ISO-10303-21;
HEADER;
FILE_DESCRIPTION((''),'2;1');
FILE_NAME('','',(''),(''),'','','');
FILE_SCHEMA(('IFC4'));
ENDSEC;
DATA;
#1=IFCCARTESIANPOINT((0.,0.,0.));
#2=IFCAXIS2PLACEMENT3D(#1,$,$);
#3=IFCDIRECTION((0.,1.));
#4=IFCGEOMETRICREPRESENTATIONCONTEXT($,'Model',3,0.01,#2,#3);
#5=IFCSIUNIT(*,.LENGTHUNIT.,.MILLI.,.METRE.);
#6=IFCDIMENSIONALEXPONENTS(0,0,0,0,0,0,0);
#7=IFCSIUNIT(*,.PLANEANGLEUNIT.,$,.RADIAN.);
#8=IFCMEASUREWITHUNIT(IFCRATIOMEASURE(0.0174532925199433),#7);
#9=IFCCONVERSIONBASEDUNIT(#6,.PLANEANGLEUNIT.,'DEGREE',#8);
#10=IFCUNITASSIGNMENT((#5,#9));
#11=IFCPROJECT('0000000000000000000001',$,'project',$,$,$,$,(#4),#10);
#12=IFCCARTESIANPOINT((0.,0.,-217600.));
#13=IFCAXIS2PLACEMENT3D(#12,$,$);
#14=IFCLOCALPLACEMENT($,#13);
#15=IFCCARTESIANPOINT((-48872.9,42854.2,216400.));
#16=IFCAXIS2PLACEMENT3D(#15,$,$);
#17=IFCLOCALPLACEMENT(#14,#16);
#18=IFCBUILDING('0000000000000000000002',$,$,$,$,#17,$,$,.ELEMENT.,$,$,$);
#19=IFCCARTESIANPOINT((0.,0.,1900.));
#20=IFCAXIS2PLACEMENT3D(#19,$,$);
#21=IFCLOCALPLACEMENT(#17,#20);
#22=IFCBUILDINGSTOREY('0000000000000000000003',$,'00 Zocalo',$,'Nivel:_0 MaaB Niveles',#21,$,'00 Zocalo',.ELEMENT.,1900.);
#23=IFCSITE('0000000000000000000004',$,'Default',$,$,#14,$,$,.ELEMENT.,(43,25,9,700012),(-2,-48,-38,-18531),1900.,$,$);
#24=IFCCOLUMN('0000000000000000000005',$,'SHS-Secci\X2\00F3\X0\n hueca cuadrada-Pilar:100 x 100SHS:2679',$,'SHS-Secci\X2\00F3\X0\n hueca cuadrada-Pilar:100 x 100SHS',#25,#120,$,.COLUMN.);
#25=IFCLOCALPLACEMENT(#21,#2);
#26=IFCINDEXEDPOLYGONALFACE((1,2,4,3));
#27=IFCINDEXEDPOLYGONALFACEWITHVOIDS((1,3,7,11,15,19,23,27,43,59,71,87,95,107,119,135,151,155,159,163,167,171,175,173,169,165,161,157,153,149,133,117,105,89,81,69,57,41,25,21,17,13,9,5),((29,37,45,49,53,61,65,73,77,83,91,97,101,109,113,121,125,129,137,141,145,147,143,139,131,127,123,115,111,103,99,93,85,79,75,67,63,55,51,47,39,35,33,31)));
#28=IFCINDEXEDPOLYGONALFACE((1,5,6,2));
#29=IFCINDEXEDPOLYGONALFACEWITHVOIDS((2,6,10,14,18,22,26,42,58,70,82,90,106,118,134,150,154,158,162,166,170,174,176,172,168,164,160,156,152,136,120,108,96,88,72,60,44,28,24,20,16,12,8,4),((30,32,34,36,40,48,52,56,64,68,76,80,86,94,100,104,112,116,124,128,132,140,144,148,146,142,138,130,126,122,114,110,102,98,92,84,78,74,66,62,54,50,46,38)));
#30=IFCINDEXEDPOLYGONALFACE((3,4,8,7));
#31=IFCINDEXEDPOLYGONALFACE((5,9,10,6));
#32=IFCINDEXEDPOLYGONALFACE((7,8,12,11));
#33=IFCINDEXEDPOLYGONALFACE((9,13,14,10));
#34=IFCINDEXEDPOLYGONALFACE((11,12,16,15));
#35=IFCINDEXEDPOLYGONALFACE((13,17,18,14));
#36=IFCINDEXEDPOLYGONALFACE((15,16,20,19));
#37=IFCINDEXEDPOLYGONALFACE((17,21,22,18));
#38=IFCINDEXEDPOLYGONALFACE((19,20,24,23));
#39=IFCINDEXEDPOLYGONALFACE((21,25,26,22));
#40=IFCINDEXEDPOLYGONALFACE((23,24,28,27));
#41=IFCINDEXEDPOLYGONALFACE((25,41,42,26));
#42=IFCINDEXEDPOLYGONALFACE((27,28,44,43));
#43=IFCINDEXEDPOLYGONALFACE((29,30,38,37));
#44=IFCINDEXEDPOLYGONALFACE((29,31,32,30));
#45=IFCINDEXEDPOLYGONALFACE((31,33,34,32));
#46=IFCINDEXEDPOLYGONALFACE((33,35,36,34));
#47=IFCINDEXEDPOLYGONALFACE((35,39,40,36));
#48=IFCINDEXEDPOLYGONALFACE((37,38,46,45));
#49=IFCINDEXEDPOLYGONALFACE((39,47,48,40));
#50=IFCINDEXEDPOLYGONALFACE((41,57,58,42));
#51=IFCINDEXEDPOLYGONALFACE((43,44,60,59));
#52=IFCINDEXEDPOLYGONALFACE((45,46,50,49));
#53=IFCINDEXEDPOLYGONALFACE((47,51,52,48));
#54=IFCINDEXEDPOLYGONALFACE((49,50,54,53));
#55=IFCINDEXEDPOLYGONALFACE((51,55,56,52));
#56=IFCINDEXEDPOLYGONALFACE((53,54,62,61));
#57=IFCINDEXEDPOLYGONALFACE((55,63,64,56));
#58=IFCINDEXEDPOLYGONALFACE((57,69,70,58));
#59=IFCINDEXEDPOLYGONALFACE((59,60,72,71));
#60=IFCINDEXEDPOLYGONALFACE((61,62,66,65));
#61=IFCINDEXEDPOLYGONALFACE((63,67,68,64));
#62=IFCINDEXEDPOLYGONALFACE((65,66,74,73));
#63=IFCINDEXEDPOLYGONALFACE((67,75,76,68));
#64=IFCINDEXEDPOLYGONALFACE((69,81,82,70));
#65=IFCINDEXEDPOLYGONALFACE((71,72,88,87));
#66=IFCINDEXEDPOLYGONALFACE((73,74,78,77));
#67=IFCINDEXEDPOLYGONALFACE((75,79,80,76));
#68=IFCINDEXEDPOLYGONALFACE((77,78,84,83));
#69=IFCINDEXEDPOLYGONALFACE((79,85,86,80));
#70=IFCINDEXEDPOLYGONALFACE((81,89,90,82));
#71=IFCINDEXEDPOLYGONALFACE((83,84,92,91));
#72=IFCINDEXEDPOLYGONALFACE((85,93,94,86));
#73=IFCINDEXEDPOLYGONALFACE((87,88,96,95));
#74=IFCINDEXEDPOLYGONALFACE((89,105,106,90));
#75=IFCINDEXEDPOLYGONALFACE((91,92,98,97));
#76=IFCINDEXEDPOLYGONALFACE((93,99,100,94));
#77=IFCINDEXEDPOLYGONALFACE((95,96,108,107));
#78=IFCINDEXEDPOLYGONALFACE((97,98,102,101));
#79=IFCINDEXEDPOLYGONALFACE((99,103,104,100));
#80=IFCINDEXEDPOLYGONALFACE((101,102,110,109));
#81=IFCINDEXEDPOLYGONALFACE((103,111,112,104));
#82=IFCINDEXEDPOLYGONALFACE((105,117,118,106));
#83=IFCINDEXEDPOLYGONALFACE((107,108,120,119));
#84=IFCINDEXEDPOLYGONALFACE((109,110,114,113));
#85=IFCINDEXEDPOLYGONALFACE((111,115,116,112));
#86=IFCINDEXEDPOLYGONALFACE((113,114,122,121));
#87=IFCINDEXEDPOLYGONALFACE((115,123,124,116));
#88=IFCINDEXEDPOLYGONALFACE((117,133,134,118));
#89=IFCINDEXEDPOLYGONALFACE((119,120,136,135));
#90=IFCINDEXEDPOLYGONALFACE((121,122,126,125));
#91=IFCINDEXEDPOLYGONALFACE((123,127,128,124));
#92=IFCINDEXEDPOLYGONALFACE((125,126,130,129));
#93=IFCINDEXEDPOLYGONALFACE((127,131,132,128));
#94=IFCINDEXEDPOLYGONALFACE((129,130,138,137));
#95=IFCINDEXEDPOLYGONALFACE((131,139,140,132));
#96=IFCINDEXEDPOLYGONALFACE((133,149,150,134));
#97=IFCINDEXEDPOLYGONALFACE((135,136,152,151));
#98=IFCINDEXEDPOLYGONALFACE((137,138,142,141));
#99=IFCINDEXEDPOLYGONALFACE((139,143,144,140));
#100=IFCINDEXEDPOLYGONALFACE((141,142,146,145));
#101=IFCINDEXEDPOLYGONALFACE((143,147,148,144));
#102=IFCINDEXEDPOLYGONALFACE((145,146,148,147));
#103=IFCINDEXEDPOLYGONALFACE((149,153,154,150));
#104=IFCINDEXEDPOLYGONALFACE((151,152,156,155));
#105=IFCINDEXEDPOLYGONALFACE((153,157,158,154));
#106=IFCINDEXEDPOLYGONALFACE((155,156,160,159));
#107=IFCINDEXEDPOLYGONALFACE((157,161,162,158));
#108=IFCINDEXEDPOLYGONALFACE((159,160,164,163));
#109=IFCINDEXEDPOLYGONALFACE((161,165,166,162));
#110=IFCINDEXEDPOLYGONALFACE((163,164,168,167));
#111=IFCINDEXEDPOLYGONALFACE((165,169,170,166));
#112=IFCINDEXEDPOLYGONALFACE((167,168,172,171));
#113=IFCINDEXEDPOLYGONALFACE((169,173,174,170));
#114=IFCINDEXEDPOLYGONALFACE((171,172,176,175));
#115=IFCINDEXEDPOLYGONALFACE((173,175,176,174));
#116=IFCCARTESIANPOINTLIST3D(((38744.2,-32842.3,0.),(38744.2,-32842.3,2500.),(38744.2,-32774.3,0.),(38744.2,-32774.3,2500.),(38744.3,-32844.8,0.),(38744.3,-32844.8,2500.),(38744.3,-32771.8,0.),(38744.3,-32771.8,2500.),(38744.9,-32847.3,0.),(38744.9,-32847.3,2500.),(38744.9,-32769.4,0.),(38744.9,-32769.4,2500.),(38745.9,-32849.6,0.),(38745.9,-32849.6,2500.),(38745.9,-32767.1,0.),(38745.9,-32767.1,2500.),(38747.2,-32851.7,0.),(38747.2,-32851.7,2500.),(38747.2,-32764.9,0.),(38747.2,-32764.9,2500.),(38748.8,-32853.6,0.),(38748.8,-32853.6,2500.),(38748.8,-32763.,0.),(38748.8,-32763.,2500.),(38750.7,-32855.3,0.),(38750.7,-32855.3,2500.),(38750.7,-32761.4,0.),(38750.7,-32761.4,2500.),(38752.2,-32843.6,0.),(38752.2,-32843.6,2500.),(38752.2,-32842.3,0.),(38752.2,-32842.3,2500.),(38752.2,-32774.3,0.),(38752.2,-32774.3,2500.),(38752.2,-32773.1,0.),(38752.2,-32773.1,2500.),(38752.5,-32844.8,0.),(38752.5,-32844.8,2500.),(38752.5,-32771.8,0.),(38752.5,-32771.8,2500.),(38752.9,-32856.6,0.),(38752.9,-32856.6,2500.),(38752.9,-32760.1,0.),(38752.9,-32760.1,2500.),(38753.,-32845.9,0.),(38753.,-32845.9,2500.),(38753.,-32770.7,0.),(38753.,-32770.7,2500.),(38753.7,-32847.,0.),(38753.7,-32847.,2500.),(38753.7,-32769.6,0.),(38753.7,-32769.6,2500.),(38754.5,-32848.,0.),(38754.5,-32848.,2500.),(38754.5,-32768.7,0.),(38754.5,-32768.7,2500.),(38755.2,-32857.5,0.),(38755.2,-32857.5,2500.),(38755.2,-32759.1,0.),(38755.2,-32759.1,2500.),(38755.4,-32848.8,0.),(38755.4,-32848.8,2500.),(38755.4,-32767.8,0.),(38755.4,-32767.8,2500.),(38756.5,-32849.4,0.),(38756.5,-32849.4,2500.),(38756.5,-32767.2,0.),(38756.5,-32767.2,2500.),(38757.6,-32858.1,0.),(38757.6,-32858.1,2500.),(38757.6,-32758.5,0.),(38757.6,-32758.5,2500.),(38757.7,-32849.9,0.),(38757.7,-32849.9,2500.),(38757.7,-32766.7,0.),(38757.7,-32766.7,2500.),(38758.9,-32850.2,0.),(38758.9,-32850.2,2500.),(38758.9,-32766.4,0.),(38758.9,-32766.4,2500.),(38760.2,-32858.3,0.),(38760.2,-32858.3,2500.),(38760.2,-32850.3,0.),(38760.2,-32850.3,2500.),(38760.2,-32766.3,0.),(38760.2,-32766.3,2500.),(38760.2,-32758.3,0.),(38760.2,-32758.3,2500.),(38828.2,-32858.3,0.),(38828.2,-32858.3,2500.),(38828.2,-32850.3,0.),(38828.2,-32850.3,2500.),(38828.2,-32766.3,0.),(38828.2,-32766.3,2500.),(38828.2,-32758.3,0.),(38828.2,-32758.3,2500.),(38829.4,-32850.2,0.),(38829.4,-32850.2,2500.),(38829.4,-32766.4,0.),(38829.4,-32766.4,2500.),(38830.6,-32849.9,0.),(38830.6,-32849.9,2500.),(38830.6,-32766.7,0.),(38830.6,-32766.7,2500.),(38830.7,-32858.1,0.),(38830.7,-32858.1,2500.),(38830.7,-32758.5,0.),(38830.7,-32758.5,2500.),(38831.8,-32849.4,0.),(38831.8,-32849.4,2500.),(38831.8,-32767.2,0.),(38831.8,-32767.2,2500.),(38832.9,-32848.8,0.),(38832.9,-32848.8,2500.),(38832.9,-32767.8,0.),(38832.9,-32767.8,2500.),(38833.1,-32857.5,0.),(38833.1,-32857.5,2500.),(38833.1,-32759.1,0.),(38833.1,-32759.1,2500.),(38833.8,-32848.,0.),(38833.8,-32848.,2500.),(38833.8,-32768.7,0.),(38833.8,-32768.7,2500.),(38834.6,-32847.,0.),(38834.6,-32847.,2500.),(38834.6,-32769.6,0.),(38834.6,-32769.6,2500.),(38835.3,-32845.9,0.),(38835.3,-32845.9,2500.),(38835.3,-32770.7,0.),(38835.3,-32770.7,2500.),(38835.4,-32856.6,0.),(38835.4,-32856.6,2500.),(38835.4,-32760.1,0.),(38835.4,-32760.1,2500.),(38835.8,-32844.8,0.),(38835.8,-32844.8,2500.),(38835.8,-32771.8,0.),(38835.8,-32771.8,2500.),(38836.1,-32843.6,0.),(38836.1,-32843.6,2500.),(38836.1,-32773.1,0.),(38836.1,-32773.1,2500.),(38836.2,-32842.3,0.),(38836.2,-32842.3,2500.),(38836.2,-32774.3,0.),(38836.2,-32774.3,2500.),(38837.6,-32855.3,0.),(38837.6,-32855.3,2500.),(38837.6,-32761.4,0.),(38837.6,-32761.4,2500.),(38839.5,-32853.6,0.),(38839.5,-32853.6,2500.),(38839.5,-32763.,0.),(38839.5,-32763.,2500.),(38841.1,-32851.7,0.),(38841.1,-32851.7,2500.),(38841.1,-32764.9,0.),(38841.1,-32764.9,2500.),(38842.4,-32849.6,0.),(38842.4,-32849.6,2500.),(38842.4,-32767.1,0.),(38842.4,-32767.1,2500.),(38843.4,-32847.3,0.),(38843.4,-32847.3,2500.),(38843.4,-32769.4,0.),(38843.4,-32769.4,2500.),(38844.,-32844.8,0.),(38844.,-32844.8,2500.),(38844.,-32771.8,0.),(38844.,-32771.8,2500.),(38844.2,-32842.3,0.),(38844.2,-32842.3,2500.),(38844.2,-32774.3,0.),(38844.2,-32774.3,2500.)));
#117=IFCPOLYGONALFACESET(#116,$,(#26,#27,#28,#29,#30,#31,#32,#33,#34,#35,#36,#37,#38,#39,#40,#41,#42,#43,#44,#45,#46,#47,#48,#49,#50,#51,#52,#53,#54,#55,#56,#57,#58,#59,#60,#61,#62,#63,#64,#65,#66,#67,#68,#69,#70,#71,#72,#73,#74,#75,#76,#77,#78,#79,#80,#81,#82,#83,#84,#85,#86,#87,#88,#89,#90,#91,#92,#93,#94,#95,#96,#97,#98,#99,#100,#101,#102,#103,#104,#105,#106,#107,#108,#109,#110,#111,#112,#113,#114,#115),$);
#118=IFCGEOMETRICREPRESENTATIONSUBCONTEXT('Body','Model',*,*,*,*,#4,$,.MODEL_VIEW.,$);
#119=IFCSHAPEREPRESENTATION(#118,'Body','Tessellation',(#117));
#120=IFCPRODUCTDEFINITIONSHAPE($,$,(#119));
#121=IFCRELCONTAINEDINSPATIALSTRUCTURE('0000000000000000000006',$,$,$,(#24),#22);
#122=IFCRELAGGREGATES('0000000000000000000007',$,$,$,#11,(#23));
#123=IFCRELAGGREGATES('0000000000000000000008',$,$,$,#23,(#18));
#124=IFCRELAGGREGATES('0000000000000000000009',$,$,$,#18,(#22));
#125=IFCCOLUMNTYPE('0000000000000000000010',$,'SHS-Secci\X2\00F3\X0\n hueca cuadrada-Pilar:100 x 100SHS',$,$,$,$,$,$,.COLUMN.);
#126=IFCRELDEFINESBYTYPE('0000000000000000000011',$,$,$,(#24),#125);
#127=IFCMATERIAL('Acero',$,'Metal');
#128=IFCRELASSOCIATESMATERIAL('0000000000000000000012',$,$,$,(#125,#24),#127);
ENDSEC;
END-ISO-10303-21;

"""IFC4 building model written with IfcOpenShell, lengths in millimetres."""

from ifc_helpers import new_model, entity, si_unit, converted_unit, direction, frame, origin, place, context, subcontext, project, spatial, indexed_curve, outline, extrude, source, transform, mapped, material, type_object, type_shapes, element, save


model = new_model("IFC4")

# Units and contexts
model_context = context("Model", 3, precision=0.01, world=origin(), true_north=direction((0.0, 1.0)))
body_context = subcontext(model_context, "Body", "Model", "MODEL_VIEW")
ifc_project = project(units=[si_unit("LENGTHUNIT", "METRE", prefix="MILLI"), converted_unit("PLANEANGLEUNIT", "DEGREE", entity("IfcRatioMeasure", 0.0174532925199433), si_unit("PLANEANGLEUNIT", "RADIAN"), dimensions=[0, 0, 0, 0, 0, 0, 0])], contexts=[model_context])

# Site, building, storey
site_placement = place(None, frame((0.0, 0.0, -217600.0)))
site = spatial("IfcSite", under=ifc_project, at=site_placement, Name="Default", CompositionType="ELEMENT", RefLatitude=(43, 25, 9, 700012), RefLongitude=(-2, -48, -38, -18531), RefElevation=1900.0)
building_placement = place(site_placement, frame((-48872.9, 42854.2, 216400.0)))
building = spatial("IfcBuilding", under=site, at=building_placement, CompositionType="ELEMENT")
storey_placement = place(building_placement, frame((0.0, 0.0, 1900.0)))
storey = spatial("IfcBuildingStorey", under=building, at=storey_placement, Name="00 Zocalo", ObjectType="Nivel:_0 MaaB Niveles", LongName="00 Zocalo", CompositionType="ELEMENT", Elevation=1900.0)

# Column
ifc_material = material(Name="Acero", Category="Metal")
column_type_1 = type_object("IfcColumnType", Name="SHS-Sección hueca cuadrada-Pilar:100 x 100SHS", PredefinedType="COLUMN", material=ifc_material)
shared_shape_1 = source(origin(), body_context, "Body", "SweptSolid", [
    extrude(outline(indexed_curve([(34.0, -50.0), (36.5, -49.8), (38.9, -49.2), (41.3, -48.3), (43.4, -46.9), (45.3, -45.3), (46.9, -43.4), (48.3, -41.3), (49.2, -38.9), (49.8, -36.5), (50.0, -34.0), (50.0, 34.0), (49.8, 36.5), (49.2, 38.9), (48.3, 41.3), (46.9, 43.4), (45.3, 45.3), (43.4, 46.9), (41.3, 48.3), (38.9, 49.2), (36.5, 49.8), (34.0, 50.0), (-34.0, 50.0), (-36.5, 49.8), (-38.9, 49.2), (-41.3, 48.3), (-43.4, 46.9), (-45.3, 45.3), (-46.9, 43.4), (-48.3, 41.3), (-49.2, 38.9), (-49.8, 36.5), (-50.0, 34.0), (-50.0, -34.0), (-49.8, -36.5), (-49.2, -38.9), (-48.3, -41.3), (-46.9, -43.4), (-45.3, -45.3), (-43.4, -46.9), (-41.3, -48.3), (-38.9, -49.2), (-36.5, -49.8), (-34.0, -50.0), (34.0, -50.0)], self_intersect=False), holes=[indexed_curve([(34.0, -42.0), (-34.0, -42.0), (-35.3, -41.9), (-36.5, -41.6), (-37.6, -41.1), (-38.7, -40.5), (-39.7, -39.7), (-40.5, -38.7), (-41.1, -37.6), (-41.6, -36.5), (-41.9, -35.3), (-42.0, -34.0), (-42.0, 34.0), (-41.9, 35.3), (-41.6, 36.5), (-41.1, 37.6), (-40.5, 38.7), (-39.7, 39.7), (-38.7, 40.5), (-37.6, 41.1), (-36.5, 41.6), (-35.3, 41.9), (-34.0, 42.0), (34.0, 42.0), (35.3, 41.9), (36.5, 41.6), (37.6, 41.1), (38.7, 40.5), (39.7, 39.7), (40.5, 38.7), (41.1, 37.6), (41.6, 36.5), (41.9, 35.3), (42.0, 34.0), (42.0, -34.0), (41.9, -35.3), (41.6, -36.5), (41.1, -37.6), (40.5, -38.7), (39.7, -39.7), (38.7, -40.5), (37.6, -41.1), (36.5, -41.6), (35.3, -41.9), (34.0, -42.0)], self_intersect=False)]), frame((0.0, 0.0, 1900.0)), (0.0, 0.0, 1.0), 2500.0),
])
type_shapes(column_type_1, [shared_shape_1])
column_1_placement = place(storey_placement, frame((38794.2, -32808.3, -1900.0), z_axis=(0.0, 0.0, 1.0), x_axis=(0.0, -1.0, 0.0)))
element("IfcColumn", 1, at=column_1_placement, inside=storey, type_object=column_type_1, material=ifc_material, Name="SHS-Sección hueca cuadrada-Pilar:100 x 100SHS:2679", ObjectType="SHS-Sección hueca cuadrada-Pilar:100 x 100SHS", PredefinedType="COLUMN", context=body_context, shape_type="MappedRepresentation", body=[
    mapped(shared_shape_1, transform((0.0, 0.0, 0.0), scale=1.0)),
])

save(model, "model.ifc")
